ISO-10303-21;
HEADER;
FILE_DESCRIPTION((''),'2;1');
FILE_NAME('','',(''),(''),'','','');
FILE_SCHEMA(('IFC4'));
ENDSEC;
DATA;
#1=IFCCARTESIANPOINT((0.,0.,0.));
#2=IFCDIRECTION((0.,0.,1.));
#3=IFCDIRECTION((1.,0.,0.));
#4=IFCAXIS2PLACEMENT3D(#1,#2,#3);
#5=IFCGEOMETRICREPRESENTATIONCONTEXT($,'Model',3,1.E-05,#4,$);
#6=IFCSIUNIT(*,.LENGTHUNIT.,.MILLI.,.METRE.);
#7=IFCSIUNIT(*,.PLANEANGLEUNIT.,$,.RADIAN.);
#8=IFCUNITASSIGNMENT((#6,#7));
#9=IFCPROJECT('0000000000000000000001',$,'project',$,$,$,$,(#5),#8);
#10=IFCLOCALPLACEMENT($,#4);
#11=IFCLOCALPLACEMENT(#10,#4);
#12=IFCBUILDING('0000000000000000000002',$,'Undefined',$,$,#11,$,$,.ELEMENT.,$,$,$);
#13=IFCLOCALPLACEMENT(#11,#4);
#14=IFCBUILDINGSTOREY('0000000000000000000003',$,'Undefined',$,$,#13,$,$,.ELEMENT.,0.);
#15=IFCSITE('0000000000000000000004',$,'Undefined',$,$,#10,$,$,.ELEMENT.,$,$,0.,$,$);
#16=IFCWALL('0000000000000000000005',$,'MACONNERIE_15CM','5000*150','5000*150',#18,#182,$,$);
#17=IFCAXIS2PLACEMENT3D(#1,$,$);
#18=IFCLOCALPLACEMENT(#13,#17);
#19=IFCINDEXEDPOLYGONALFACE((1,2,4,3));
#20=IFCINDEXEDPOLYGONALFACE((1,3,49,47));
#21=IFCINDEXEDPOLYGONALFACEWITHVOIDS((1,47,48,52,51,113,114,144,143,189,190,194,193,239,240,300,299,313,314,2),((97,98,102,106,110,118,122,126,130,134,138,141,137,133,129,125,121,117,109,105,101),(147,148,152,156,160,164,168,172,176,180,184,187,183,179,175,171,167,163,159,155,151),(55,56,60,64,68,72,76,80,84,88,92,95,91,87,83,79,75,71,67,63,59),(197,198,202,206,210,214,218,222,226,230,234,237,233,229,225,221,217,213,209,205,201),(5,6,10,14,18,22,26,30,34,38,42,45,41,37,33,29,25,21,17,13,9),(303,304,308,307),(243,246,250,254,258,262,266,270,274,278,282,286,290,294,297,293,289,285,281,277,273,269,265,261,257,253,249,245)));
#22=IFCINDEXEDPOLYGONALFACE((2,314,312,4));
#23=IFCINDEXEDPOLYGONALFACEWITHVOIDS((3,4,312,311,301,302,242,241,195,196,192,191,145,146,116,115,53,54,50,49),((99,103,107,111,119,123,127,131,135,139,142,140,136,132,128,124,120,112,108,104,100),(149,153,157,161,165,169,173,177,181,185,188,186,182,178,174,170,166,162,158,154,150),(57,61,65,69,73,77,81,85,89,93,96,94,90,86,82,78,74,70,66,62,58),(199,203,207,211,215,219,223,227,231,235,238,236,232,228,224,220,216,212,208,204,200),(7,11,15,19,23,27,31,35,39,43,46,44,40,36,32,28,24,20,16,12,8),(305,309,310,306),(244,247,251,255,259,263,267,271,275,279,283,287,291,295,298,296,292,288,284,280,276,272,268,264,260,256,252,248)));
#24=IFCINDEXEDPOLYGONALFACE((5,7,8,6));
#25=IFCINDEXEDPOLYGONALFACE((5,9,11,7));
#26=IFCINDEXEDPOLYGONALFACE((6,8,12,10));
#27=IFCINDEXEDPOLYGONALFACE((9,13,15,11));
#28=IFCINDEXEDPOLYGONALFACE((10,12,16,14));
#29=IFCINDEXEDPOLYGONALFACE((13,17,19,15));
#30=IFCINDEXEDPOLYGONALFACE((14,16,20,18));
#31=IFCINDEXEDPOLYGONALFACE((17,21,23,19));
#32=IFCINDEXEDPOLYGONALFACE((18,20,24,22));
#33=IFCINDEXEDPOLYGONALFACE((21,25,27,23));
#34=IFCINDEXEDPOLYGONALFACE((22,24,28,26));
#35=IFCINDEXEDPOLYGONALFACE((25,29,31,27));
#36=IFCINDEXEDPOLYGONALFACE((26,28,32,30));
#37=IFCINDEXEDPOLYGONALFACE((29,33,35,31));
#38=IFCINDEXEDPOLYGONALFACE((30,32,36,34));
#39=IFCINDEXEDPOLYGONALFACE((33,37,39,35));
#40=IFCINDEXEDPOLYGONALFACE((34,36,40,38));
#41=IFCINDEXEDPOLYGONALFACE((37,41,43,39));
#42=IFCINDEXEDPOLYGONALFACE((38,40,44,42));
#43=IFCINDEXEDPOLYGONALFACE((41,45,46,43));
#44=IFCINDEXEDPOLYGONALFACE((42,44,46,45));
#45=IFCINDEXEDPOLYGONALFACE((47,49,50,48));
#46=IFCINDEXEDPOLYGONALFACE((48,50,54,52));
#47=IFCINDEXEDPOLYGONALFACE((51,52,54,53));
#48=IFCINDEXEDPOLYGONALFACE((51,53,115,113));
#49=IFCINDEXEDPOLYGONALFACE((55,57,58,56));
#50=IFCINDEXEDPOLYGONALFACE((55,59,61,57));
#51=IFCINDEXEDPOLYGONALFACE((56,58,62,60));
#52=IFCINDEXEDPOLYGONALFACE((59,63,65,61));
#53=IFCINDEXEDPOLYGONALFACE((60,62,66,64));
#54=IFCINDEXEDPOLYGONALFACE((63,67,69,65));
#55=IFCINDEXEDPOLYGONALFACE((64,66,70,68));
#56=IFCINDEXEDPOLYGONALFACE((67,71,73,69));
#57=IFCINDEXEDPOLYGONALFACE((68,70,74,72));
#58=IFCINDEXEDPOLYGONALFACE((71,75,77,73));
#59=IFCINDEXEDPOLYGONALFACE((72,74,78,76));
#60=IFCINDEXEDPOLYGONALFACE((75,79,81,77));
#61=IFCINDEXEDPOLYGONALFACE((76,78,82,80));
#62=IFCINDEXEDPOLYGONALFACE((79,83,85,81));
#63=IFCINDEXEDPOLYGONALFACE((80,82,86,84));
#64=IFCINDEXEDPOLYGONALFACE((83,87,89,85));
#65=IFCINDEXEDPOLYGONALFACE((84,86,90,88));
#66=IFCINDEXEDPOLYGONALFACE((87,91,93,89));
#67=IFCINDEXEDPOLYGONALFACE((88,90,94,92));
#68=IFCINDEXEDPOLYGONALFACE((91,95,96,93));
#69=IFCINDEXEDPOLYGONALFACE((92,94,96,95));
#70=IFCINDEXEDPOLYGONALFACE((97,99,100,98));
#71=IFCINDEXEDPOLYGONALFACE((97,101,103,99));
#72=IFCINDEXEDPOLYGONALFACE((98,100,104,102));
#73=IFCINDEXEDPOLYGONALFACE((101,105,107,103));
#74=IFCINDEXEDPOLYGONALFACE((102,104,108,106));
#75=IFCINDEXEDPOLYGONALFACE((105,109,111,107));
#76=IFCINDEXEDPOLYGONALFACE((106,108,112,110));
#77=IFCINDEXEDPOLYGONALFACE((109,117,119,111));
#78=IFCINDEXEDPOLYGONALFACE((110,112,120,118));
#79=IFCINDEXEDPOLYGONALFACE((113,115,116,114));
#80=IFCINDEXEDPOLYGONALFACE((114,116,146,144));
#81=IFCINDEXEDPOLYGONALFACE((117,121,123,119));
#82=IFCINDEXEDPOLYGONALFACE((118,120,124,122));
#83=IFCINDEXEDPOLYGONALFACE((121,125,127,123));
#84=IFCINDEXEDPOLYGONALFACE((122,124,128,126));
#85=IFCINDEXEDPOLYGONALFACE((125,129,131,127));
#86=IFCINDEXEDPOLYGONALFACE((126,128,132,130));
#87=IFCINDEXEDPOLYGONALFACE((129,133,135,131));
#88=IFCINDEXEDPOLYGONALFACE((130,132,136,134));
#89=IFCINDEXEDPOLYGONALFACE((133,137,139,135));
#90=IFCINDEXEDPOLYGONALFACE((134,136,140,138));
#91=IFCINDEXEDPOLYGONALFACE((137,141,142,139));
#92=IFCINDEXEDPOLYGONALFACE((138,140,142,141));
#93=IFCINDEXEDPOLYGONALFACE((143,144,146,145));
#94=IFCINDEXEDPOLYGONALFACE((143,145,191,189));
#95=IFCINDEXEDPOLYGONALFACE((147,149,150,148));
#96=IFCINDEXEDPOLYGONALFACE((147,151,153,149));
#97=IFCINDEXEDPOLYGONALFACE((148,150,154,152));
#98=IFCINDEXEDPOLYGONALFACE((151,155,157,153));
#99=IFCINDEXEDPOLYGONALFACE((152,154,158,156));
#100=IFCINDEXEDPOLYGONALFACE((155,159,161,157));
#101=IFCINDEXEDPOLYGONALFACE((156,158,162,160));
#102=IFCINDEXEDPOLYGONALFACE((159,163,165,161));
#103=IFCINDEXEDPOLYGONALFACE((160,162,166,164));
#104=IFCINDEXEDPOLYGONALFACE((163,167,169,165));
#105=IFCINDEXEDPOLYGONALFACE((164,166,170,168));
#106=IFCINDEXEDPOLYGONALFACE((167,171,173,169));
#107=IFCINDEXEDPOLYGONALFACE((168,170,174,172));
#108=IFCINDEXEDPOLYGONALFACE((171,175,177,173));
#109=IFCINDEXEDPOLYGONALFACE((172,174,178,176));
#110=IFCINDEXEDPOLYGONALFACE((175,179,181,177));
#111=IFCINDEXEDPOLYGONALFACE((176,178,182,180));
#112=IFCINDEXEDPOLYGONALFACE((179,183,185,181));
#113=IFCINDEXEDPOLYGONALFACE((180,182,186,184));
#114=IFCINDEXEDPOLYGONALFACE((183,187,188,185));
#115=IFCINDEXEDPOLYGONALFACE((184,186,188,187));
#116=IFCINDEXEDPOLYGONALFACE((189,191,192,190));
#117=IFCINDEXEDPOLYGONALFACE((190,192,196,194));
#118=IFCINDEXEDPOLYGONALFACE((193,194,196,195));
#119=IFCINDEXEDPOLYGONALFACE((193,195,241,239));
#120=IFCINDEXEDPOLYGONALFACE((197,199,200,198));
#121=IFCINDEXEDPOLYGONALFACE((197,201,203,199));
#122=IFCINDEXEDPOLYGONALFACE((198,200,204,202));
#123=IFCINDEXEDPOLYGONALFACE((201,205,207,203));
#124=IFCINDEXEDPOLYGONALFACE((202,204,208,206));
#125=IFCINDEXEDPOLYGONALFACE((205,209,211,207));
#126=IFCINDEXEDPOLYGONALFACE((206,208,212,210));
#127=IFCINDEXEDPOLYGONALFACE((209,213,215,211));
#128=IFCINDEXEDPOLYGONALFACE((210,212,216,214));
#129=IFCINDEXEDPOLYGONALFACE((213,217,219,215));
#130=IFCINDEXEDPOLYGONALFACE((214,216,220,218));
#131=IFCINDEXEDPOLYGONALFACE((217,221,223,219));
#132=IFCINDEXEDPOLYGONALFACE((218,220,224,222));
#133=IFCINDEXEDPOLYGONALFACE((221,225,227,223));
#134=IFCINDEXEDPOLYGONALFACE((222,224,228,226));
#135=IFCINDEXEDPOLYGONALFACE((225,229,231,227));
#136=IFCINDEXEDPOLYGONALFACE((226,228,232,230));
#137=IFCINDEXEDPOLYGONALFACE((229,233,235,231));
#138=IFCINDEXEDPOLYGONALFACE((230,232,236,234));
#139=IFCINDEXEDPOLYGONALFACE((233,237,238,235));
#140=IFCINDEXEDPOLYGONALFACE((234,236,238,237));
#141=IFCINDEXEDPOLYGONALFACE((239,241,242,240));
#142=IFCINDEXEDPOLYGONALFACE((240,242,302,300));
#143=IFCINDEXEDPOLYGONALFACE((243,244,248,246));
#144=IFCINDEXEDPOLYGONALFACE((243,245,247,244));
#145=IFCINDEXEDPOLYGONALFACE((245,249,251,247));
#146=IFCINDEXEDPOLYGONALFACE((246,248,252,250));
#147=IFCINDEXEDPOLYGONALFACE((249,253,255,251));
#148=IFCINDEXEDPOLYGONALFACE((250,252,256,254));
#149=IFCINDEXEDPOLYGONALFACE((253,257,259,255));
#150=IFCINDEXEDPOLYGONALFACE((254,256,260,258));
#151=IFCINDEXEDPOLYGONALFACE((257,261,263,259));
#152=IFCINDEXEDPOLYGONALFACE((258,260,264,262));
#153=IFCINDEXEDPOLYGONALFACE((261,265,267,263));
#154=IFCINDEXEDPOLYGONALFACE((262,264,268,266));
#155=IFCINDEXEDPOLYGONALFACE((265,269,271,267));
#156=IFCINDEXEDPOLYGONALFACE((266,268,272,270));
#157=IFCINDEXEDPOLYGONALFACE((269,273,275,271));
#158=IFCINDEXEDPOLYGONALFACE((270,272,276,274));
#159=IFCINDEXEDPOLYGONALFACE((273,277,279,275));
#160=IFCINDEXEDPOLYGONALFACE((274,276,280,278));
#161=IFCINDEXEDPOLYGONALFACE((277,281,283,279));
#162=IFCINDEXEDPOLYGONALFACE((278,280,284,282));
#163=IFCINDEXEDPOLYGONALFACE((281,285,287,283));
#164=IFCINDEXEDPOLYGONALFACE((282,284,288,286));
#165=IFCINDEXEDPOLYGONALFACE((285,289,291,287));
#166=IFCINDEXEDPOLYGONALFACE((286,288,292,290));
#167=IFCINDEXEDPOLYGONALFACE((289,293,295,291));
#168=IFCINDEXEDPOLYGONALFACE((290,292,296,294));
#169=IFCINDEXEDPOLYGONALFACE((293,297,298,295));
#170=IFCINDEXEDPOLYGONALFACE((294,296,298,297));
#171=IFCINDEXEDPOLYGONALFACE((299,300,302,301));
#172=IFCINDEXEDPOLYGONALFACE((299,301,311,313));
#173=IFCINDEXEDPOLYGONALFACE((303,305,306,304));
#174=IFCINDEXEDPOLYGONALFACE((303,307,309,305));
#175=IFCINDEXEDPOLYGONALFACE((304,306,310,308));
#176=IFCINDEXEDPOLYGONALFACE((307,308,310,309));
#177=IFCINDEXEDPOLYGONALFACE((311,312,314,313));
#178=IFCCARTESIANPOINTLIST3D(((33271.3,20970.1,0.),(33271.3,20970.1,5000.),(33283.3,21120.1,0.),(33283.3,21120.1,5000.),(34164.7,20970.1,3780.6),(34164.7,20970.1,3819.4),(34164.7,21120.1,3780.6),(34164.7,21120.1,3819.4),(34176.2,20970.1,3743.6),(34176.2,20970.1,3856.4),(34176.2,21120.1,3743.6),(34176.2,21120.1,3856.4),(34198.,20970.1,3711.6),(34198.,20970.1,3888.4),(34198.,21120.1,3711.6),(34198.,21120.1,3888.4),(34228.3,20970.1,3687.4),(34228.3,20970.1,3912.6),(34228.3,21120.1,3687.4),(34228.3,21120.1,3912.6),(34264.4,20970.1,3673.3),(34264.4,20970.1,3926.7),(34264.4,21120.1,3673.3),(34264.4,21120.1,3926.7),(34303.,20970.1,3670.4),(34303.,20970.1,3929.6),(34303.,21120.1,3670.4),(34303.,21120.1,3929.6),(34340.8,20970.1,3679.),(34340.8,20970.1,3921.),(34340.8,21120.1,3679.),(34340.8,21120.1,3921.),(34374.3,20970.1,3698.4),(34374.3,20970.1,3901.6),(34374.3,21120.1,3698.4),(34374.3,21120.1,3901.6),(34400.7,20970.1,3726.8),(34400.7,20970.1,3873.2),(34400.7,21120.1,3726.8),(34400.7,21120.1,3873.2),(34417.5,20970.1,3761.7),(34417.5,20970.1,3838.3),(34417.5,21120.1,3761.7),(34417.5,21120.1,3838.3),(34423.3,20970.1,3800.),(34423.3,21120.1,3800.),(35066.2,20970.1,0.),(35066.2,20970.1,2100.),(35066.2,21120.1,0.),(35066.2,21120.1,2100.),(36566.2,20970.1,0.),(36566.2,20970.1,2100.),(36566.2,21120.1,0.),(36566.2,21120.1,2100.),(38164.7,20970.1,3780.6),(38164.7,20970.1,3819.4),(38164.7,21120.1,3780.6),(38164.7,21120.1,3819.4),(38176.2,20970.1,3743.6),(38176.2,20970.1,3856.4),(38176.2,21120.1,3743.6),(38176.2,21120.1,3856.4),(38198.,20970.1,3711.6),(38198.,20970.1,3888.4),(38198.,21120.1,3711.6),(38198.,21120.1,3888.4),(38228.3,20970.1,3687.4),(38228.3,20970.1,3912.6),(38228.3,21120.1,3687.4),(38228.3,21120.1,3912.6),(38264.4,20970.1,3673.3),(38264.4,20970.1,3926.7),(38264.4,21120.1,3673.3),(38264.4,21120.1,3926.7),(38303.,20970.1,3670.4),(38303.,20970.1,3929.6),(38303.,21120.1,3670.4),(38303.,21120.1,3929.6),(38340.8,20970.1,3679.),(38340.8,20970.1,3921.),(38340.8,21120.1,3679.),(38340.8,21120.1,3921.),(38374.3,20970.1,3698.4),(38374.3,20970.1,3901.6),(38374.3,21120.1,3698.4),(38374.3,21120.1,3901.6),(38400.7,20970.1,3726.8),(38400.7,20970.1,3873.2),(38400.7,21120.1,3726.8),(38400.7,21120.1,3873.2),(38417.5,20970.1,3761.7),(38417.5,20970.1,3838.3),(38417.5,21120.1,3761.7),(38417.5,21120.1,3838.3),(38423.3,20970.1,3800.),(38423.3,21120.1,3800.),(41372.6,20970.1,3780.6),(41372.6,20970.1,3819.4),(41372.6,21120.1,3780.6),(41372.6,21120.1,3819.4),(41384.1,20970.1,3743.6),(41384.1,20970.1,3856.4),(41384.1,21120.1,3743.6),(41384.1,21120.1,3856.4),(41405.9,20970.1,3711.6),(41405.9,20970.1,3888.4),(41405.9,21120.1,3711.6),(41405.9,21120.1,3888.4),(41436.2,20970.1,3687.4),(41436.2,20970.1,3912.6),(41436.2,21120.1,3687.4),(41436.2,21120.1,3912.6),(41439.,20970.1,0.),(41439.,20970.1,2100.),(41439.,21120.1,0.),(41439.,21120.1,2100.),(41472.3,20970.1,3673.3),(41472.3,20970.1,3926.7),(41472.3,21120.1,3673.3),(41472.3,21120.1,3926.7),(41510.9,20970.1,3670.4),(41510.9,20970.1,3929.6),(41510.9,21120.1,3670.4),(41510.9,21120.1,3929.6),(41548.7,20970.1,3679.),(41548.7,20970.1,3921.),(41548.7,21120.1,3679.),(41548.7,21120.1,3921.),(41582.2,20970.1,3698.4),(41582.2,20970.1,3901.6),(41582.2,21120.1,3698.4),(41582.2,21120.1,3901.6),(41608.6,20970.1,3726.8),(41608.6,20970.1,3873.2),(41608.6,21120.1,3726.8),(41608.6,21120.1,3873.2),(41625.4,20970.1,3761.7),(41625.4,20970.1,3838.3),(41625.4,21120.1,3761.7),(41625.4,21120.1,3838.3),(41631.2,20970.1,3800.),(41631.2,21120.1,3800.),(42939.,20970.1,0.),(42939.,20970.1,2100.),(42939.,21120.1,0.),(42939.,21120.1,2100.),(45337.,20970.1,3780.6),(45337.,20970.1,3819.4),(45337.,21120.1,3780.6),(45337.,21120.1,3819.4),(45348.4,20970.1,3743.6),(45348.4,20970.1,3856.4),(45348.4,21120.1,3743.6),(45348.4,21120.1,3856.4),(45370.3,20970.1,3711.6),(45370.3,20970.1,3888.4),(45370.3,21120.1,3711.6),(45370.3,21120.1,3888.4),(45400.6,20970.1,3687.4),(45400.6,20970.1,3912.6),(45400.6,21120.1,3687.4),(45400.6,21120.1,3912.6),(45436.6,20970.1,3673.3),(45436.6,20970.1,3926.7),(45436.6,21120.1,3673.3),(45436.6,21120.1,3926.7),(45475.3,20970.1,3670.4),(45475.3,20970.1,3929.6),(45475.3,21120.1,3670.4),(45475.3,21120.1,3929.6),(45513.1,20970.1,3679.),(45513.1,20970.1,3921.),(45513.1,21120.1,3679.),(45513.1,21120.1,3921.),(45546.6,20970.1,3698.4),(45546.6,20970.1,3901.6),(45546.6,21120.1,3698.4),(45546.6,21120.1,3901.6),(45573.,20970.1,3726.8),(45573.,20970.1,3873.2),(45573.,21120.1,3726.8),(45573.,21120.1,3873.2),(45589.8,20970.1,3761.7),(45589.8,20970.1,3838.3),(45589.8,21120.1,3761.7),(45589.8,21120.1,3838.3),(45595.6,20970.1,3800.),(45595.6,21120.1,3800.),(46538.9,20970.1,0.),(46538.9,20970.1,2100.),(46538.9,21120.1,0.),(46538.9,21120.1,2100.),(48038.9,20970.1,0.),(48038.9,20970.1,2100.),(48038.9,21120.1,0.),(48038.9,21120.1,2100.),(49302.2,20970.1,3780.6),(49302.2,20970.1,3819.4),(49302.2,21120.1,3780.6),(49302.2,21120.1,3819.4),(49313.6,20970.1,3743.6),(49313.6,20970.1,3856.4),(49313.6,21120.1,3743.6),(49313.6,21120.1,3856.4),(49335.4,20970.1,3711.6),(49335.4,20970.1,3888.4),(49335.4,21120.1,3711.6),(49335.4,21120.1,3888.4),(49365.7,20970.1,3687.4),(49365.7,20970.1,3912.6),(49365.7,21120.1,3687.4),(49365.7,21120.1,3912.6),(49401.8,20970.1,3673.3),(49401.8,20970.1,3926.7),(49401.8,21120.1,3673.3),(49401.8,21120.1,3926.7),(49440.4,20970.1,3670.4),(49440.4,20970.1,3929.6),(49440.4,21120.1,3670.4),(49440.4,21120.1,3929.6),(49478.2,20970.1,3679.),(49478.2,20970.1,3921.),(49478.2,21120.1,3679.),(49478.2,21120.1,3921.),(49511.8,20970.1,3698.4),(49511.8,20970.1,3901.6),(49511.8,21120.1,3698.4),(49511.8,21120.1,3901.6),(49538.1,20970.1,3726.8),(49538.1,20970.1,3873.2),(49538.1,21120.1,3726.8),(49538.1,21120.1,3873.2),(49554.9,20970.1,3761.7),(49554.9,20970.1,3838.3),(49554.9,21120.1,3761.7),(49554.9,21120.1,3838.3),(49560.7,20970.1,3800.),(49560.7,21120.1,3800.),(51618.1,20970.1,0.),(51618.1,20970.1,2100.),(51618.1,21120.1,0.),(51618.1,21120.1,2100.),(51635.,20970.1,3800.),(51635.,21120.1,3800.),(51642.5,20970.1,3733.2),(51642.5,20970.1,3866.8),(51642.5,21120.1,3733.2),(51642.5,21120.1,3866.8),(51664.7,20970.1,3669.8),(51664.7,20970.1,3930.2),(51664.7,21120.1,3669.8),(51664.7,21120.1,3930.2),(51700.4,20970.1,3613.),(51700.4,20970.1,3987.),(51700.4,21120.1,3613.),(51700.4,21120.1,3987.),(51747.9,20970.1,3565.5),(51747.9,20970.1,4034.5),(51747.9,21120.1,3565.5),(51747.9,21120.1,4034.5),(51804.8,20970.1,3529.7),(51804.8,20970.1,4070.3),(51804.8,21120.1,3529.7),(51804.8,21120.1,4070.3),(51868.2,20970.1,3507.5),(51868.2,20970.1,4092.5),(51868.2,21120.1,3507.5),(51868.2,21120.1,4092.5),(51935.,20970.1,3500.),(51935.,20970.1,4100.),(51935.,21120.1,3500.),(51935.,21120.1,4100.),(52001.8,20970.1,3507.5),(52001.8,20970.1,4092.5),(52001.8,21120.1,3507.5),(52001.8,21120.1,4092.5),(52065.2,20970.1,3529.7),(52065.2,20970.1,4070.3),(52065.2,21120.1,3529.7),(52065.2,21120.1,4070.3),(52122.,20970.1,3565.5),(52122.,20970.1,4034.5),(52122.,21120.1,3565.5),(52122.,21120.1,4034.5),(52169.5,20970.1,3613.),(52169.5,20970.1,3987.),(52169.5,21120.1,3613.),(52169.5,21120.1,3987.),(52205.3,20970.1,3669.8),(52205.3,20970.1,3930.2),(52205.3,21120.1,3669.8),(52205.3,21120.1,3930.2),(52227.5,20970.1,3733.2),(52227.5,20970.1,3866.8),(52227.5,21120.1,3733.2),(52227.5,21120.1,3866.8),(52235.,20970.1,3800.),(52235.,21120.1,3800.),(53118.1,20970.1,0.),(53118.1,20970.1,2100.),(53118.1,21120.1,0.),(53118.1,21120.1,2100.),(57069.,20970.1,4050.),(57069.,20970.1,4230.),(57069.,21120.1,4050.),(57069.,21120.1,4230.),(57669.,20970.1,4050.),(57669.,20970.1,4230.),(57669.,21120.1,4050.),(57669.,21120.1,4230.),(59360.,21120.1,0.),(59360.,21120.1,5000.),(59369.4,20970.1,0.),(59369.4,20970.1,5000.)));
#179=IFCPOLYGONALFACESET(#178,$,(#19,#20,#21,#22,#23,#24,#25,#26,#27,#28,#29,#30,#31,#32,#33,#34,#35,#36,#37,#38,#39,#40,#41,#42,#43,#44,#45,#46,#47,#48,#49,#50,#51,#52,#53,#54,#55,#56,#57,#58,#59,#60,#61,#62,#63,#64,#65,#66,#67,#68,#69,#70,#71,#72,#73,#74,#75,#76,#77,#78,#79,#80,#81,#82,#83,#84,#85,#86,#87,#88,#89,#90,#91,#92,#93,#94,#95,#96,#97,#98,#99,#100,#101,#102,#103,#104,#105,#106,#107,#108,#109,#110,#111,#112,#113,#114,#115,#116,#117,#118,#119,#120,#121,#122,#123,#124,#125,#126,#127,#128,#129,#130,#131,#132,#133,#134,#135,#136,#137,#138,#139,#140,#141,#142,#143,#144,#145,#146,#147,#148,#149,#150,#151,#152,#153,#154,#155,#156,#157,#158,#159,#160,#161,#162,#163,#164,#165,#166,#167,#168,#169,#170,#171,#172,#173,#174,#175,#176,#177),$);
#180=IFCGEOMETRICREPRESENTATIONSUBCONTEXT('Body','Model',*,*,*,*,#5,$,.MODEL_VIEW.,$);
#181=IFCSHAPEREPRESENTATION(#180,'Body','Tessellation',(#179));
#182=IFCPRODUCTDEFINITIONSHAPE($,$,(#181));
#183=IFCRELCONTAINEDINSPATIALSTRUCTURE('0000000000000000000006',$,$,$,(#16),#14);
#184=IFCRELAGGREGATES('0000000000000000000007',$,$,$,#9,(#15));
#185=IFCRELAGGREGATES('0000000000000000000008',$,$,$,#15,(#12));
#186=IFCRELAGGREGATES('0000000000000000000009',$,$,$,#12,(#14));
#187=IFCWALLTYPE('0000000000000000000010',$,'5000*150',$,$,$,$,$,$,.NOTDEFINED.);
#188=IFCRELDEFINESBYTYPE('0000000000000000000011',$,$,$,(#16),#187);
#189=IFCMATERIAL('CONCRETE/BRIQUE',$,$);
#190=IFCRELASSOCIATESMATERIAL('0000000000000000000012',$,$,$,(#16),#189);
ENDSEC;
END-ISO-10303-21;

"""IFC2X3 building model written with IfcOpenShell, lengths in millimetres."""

from ifc_helpers import new_model, si_unit, frame, frame_2d, origin_with_axes, origin_2d_with_axis, place, context, subcontext, project, spatial, polyline, rectangle, circle, outline, extrude, boolean, halfspace, material, type_object, element, save


model = new_model("IFC2X3")

# Units and contexts
model_context = context("Model", 3, precision=1e-05, world=origin_with_axes())
body_context = subcontext(model_context, "Body", "Model", "MODEL_VIEW")
ifc_project = project(units=[si_unit("LENGTHUNIT", "METRE", prefix="MILLI"), si_unit("PLANEANGLEUNIT", "RADIAN")], contexts=[model_context])

# Site, building, storey
site_placement = place(None, origin_with_axes())
site = spatial("IfcSite", under=ifc_project, at=site_placement, Name="Undefined", CompositionType="ELEMENT", RefElevation=0.0)
building_placement = place(site_placement, origin_with_axes())
building = spatial("IfcBuilding", under=site, at=building_placement, Name="Undefined", CompositionType="ELEMENT")
storey_placement = place(building_placement, origin_with_axes())
storey = spatial("IfcBuildingStorey", under=building, at=storey_placement, Name="Undefined", CompositionType="ELEMENT", Elevation=0.0)

# Wall
ifc_material_1 = material(Name="CONCRETE/BRIQUE")
wall_type_1 = type_object("IfcWallType", Name="5000*150", PredefinedType="NOTDEFINED")
wall_1_placement = place(storey_placement, frame((59369.4, 21045.1, 0.0), z_axis=(0.0, 0.0, 1.0), x_axis=(-1.0, 0.0, 0.0)))
solid_1 = boolean("DIFFERENCE", boolean("DIFFERENCE", boolean("DIFFERENCE", boolean("DIFFERENCE", boolean("DIFFERENCE", boolean("DIFFERENCE", boolean("DIFFERENCE", boolean("DIFFERENCE", extrude(rectangle(XDim=26134.4, YDim=150.0, at=frame_2d((0.0, 13048.4), x_axis=(0.0, -1.0))), frame((0.0, 0.0, 0.0), z_axis=(0.0, 0.0, 1.0), x_axis=(0.0, -1.0, 0.0)), (0.0, 0.0, 1.0), 5000.0), extrude(circle(Radius=300.0, at=origin_2d_with_axis()), frame((7434.4, -85.0, 3800.0), z_axis=(0.0, 1.0, 0.0), x_axis=(-1.0, 0.0, 0.0)), (0.0, 0.0, 1.0), 170.0)), extrude(circle(Radius=130.0, at=origin_2d_with_axis()), frame((9938.7, -85.0, 3800.0), z_axis=(0.0, 1.0, 0.0), x_axis=(-1.0, 0.0, 0.0)), (0.0, 0.0, 1.0), 170.0)), extrude(circle(Radius=130.0, at=origin_2d_with_axis()), frame((13903.9, -85.0, 3800.0), z_axis=(0.0, 1.0, 0.0), x_axis=(-1.0, 0.0, 0.0)), (0.0, 0.0, 1.0), 170.0)), extrude(circle(Radius=130.0, at=origin_2d_with_axis()), frame((17868.2, -85.0, 3800.0), z_axis=(0.0, 1.0, 0.0), x_axis=(-1.0, 0.0, 0.0)), (0.0, 0.0, 1.0), 170.0)), extrude(circle(Radius=130.0, at=origin_2d_with_axis()), frame((21076.1, -85.0, 3800.0), z_axis=(0.0, 1.0, 0.0), x_axis=(-1.0, 0.0, 0.0)), (0.0, 0.0, 1.0), 170.0)), extrude(circle(Radius=130.0, at=origin_2d_with_axis()), frame((25076.1, -85.0, 3800.0), z_axis=(0.0, 1.0, 0.0), x_axis=(-1.0, 0.0, 0.0)), (0.0, 0.0, 1.0), 170.0)), extrude(rectangle(XDim=600.0, YDim=180.0, at=origin_2d_with_axis()), frame((2000.4, -85.0, 4140.0), z_axis=(0.0, 1.0, 0.0), x_axis=(-1.0, 0.0, 0.0)), (0.0, 0.0, 1.0), 170.0)), extrude(outline(polyline([(0.0, 0.0), (2100.0, 0.0), (2100.0, 1500.0), (0.0, 1500.0), (0.0, 0.0)])), frame((7751.3, -85.0, 2100.0), z_axis=(0.0, 1.0, 0.0), x_axis=(0.0, 0.0, -1.0)), (0.0, 0.0, 1.0), 170.0))
element("IfcWall", 1, at=wall_1_placement, inside=storey, type_object=wall_type_1, material=ifc_material_1, Name="MACONNERIE_15CM", Description="5000*150", ObjectType="5000*150", context=body_context, shape_type="CSG", body=[
    boolean("DIFFERENCE", boolean("DIFFERENCE", boolean("DIFFERENCE", boolean("DIFFERENCE", boolean("DIFFERENCE", solid_1, extrude(outline(polyline([(0.0, 0.0), (2100.0, 0.0), (2100.0, 1500.0), (0.0, 1500.0), (0.0, 0.0)])), frame((12830.6, -85.0, 2100.0), z_axis=(0.0, 1.0, 0.0), x_axis=(0.0, 0.0, -1.0)), (0.0, 0.0, 1.0), 170.0)), extrude(outline(polyline([(0.0, 0.0), (2100.0, 0.0), (2100.0, 1500.0), (0.0, 1500.0), (0.0, 0.0)])), frame((17930.5, -85.0, 2100.0), z_axis=(0.0, 1.0, 0.0), x_axis=(0.0, 0.0, -1.0)), (0.0, 0.0, 1.0), 170.0)), extrude(outline(polyline([(0.0, 0.0), (2100.0, 0.0), (2100.0, 1500.0), (0.0, 1500.0), (0.0, 0.0)])), frame((24303.2, -85.0, 2100.0), z_axis=(0.0, 1.0, 0.0), x_axis=(0.0, 0.0, -1.0)), (0.0, 0.0, 1.0), 170.0)), halfspace(frame((26092.1, 0.0, 1500.0), z_axis=(-0.996856, 0.07924, 0.0), x_axis=(0.07924, 0.996856, 0.0)), True)), halfspace(frame((9.4, -75.0, 2500.0), z_axis=(0.99803, 0.062737, 0.0), x_axis=(0.0, 0.0, 1.0)), True)),
])

save(model, "model.ifc")
